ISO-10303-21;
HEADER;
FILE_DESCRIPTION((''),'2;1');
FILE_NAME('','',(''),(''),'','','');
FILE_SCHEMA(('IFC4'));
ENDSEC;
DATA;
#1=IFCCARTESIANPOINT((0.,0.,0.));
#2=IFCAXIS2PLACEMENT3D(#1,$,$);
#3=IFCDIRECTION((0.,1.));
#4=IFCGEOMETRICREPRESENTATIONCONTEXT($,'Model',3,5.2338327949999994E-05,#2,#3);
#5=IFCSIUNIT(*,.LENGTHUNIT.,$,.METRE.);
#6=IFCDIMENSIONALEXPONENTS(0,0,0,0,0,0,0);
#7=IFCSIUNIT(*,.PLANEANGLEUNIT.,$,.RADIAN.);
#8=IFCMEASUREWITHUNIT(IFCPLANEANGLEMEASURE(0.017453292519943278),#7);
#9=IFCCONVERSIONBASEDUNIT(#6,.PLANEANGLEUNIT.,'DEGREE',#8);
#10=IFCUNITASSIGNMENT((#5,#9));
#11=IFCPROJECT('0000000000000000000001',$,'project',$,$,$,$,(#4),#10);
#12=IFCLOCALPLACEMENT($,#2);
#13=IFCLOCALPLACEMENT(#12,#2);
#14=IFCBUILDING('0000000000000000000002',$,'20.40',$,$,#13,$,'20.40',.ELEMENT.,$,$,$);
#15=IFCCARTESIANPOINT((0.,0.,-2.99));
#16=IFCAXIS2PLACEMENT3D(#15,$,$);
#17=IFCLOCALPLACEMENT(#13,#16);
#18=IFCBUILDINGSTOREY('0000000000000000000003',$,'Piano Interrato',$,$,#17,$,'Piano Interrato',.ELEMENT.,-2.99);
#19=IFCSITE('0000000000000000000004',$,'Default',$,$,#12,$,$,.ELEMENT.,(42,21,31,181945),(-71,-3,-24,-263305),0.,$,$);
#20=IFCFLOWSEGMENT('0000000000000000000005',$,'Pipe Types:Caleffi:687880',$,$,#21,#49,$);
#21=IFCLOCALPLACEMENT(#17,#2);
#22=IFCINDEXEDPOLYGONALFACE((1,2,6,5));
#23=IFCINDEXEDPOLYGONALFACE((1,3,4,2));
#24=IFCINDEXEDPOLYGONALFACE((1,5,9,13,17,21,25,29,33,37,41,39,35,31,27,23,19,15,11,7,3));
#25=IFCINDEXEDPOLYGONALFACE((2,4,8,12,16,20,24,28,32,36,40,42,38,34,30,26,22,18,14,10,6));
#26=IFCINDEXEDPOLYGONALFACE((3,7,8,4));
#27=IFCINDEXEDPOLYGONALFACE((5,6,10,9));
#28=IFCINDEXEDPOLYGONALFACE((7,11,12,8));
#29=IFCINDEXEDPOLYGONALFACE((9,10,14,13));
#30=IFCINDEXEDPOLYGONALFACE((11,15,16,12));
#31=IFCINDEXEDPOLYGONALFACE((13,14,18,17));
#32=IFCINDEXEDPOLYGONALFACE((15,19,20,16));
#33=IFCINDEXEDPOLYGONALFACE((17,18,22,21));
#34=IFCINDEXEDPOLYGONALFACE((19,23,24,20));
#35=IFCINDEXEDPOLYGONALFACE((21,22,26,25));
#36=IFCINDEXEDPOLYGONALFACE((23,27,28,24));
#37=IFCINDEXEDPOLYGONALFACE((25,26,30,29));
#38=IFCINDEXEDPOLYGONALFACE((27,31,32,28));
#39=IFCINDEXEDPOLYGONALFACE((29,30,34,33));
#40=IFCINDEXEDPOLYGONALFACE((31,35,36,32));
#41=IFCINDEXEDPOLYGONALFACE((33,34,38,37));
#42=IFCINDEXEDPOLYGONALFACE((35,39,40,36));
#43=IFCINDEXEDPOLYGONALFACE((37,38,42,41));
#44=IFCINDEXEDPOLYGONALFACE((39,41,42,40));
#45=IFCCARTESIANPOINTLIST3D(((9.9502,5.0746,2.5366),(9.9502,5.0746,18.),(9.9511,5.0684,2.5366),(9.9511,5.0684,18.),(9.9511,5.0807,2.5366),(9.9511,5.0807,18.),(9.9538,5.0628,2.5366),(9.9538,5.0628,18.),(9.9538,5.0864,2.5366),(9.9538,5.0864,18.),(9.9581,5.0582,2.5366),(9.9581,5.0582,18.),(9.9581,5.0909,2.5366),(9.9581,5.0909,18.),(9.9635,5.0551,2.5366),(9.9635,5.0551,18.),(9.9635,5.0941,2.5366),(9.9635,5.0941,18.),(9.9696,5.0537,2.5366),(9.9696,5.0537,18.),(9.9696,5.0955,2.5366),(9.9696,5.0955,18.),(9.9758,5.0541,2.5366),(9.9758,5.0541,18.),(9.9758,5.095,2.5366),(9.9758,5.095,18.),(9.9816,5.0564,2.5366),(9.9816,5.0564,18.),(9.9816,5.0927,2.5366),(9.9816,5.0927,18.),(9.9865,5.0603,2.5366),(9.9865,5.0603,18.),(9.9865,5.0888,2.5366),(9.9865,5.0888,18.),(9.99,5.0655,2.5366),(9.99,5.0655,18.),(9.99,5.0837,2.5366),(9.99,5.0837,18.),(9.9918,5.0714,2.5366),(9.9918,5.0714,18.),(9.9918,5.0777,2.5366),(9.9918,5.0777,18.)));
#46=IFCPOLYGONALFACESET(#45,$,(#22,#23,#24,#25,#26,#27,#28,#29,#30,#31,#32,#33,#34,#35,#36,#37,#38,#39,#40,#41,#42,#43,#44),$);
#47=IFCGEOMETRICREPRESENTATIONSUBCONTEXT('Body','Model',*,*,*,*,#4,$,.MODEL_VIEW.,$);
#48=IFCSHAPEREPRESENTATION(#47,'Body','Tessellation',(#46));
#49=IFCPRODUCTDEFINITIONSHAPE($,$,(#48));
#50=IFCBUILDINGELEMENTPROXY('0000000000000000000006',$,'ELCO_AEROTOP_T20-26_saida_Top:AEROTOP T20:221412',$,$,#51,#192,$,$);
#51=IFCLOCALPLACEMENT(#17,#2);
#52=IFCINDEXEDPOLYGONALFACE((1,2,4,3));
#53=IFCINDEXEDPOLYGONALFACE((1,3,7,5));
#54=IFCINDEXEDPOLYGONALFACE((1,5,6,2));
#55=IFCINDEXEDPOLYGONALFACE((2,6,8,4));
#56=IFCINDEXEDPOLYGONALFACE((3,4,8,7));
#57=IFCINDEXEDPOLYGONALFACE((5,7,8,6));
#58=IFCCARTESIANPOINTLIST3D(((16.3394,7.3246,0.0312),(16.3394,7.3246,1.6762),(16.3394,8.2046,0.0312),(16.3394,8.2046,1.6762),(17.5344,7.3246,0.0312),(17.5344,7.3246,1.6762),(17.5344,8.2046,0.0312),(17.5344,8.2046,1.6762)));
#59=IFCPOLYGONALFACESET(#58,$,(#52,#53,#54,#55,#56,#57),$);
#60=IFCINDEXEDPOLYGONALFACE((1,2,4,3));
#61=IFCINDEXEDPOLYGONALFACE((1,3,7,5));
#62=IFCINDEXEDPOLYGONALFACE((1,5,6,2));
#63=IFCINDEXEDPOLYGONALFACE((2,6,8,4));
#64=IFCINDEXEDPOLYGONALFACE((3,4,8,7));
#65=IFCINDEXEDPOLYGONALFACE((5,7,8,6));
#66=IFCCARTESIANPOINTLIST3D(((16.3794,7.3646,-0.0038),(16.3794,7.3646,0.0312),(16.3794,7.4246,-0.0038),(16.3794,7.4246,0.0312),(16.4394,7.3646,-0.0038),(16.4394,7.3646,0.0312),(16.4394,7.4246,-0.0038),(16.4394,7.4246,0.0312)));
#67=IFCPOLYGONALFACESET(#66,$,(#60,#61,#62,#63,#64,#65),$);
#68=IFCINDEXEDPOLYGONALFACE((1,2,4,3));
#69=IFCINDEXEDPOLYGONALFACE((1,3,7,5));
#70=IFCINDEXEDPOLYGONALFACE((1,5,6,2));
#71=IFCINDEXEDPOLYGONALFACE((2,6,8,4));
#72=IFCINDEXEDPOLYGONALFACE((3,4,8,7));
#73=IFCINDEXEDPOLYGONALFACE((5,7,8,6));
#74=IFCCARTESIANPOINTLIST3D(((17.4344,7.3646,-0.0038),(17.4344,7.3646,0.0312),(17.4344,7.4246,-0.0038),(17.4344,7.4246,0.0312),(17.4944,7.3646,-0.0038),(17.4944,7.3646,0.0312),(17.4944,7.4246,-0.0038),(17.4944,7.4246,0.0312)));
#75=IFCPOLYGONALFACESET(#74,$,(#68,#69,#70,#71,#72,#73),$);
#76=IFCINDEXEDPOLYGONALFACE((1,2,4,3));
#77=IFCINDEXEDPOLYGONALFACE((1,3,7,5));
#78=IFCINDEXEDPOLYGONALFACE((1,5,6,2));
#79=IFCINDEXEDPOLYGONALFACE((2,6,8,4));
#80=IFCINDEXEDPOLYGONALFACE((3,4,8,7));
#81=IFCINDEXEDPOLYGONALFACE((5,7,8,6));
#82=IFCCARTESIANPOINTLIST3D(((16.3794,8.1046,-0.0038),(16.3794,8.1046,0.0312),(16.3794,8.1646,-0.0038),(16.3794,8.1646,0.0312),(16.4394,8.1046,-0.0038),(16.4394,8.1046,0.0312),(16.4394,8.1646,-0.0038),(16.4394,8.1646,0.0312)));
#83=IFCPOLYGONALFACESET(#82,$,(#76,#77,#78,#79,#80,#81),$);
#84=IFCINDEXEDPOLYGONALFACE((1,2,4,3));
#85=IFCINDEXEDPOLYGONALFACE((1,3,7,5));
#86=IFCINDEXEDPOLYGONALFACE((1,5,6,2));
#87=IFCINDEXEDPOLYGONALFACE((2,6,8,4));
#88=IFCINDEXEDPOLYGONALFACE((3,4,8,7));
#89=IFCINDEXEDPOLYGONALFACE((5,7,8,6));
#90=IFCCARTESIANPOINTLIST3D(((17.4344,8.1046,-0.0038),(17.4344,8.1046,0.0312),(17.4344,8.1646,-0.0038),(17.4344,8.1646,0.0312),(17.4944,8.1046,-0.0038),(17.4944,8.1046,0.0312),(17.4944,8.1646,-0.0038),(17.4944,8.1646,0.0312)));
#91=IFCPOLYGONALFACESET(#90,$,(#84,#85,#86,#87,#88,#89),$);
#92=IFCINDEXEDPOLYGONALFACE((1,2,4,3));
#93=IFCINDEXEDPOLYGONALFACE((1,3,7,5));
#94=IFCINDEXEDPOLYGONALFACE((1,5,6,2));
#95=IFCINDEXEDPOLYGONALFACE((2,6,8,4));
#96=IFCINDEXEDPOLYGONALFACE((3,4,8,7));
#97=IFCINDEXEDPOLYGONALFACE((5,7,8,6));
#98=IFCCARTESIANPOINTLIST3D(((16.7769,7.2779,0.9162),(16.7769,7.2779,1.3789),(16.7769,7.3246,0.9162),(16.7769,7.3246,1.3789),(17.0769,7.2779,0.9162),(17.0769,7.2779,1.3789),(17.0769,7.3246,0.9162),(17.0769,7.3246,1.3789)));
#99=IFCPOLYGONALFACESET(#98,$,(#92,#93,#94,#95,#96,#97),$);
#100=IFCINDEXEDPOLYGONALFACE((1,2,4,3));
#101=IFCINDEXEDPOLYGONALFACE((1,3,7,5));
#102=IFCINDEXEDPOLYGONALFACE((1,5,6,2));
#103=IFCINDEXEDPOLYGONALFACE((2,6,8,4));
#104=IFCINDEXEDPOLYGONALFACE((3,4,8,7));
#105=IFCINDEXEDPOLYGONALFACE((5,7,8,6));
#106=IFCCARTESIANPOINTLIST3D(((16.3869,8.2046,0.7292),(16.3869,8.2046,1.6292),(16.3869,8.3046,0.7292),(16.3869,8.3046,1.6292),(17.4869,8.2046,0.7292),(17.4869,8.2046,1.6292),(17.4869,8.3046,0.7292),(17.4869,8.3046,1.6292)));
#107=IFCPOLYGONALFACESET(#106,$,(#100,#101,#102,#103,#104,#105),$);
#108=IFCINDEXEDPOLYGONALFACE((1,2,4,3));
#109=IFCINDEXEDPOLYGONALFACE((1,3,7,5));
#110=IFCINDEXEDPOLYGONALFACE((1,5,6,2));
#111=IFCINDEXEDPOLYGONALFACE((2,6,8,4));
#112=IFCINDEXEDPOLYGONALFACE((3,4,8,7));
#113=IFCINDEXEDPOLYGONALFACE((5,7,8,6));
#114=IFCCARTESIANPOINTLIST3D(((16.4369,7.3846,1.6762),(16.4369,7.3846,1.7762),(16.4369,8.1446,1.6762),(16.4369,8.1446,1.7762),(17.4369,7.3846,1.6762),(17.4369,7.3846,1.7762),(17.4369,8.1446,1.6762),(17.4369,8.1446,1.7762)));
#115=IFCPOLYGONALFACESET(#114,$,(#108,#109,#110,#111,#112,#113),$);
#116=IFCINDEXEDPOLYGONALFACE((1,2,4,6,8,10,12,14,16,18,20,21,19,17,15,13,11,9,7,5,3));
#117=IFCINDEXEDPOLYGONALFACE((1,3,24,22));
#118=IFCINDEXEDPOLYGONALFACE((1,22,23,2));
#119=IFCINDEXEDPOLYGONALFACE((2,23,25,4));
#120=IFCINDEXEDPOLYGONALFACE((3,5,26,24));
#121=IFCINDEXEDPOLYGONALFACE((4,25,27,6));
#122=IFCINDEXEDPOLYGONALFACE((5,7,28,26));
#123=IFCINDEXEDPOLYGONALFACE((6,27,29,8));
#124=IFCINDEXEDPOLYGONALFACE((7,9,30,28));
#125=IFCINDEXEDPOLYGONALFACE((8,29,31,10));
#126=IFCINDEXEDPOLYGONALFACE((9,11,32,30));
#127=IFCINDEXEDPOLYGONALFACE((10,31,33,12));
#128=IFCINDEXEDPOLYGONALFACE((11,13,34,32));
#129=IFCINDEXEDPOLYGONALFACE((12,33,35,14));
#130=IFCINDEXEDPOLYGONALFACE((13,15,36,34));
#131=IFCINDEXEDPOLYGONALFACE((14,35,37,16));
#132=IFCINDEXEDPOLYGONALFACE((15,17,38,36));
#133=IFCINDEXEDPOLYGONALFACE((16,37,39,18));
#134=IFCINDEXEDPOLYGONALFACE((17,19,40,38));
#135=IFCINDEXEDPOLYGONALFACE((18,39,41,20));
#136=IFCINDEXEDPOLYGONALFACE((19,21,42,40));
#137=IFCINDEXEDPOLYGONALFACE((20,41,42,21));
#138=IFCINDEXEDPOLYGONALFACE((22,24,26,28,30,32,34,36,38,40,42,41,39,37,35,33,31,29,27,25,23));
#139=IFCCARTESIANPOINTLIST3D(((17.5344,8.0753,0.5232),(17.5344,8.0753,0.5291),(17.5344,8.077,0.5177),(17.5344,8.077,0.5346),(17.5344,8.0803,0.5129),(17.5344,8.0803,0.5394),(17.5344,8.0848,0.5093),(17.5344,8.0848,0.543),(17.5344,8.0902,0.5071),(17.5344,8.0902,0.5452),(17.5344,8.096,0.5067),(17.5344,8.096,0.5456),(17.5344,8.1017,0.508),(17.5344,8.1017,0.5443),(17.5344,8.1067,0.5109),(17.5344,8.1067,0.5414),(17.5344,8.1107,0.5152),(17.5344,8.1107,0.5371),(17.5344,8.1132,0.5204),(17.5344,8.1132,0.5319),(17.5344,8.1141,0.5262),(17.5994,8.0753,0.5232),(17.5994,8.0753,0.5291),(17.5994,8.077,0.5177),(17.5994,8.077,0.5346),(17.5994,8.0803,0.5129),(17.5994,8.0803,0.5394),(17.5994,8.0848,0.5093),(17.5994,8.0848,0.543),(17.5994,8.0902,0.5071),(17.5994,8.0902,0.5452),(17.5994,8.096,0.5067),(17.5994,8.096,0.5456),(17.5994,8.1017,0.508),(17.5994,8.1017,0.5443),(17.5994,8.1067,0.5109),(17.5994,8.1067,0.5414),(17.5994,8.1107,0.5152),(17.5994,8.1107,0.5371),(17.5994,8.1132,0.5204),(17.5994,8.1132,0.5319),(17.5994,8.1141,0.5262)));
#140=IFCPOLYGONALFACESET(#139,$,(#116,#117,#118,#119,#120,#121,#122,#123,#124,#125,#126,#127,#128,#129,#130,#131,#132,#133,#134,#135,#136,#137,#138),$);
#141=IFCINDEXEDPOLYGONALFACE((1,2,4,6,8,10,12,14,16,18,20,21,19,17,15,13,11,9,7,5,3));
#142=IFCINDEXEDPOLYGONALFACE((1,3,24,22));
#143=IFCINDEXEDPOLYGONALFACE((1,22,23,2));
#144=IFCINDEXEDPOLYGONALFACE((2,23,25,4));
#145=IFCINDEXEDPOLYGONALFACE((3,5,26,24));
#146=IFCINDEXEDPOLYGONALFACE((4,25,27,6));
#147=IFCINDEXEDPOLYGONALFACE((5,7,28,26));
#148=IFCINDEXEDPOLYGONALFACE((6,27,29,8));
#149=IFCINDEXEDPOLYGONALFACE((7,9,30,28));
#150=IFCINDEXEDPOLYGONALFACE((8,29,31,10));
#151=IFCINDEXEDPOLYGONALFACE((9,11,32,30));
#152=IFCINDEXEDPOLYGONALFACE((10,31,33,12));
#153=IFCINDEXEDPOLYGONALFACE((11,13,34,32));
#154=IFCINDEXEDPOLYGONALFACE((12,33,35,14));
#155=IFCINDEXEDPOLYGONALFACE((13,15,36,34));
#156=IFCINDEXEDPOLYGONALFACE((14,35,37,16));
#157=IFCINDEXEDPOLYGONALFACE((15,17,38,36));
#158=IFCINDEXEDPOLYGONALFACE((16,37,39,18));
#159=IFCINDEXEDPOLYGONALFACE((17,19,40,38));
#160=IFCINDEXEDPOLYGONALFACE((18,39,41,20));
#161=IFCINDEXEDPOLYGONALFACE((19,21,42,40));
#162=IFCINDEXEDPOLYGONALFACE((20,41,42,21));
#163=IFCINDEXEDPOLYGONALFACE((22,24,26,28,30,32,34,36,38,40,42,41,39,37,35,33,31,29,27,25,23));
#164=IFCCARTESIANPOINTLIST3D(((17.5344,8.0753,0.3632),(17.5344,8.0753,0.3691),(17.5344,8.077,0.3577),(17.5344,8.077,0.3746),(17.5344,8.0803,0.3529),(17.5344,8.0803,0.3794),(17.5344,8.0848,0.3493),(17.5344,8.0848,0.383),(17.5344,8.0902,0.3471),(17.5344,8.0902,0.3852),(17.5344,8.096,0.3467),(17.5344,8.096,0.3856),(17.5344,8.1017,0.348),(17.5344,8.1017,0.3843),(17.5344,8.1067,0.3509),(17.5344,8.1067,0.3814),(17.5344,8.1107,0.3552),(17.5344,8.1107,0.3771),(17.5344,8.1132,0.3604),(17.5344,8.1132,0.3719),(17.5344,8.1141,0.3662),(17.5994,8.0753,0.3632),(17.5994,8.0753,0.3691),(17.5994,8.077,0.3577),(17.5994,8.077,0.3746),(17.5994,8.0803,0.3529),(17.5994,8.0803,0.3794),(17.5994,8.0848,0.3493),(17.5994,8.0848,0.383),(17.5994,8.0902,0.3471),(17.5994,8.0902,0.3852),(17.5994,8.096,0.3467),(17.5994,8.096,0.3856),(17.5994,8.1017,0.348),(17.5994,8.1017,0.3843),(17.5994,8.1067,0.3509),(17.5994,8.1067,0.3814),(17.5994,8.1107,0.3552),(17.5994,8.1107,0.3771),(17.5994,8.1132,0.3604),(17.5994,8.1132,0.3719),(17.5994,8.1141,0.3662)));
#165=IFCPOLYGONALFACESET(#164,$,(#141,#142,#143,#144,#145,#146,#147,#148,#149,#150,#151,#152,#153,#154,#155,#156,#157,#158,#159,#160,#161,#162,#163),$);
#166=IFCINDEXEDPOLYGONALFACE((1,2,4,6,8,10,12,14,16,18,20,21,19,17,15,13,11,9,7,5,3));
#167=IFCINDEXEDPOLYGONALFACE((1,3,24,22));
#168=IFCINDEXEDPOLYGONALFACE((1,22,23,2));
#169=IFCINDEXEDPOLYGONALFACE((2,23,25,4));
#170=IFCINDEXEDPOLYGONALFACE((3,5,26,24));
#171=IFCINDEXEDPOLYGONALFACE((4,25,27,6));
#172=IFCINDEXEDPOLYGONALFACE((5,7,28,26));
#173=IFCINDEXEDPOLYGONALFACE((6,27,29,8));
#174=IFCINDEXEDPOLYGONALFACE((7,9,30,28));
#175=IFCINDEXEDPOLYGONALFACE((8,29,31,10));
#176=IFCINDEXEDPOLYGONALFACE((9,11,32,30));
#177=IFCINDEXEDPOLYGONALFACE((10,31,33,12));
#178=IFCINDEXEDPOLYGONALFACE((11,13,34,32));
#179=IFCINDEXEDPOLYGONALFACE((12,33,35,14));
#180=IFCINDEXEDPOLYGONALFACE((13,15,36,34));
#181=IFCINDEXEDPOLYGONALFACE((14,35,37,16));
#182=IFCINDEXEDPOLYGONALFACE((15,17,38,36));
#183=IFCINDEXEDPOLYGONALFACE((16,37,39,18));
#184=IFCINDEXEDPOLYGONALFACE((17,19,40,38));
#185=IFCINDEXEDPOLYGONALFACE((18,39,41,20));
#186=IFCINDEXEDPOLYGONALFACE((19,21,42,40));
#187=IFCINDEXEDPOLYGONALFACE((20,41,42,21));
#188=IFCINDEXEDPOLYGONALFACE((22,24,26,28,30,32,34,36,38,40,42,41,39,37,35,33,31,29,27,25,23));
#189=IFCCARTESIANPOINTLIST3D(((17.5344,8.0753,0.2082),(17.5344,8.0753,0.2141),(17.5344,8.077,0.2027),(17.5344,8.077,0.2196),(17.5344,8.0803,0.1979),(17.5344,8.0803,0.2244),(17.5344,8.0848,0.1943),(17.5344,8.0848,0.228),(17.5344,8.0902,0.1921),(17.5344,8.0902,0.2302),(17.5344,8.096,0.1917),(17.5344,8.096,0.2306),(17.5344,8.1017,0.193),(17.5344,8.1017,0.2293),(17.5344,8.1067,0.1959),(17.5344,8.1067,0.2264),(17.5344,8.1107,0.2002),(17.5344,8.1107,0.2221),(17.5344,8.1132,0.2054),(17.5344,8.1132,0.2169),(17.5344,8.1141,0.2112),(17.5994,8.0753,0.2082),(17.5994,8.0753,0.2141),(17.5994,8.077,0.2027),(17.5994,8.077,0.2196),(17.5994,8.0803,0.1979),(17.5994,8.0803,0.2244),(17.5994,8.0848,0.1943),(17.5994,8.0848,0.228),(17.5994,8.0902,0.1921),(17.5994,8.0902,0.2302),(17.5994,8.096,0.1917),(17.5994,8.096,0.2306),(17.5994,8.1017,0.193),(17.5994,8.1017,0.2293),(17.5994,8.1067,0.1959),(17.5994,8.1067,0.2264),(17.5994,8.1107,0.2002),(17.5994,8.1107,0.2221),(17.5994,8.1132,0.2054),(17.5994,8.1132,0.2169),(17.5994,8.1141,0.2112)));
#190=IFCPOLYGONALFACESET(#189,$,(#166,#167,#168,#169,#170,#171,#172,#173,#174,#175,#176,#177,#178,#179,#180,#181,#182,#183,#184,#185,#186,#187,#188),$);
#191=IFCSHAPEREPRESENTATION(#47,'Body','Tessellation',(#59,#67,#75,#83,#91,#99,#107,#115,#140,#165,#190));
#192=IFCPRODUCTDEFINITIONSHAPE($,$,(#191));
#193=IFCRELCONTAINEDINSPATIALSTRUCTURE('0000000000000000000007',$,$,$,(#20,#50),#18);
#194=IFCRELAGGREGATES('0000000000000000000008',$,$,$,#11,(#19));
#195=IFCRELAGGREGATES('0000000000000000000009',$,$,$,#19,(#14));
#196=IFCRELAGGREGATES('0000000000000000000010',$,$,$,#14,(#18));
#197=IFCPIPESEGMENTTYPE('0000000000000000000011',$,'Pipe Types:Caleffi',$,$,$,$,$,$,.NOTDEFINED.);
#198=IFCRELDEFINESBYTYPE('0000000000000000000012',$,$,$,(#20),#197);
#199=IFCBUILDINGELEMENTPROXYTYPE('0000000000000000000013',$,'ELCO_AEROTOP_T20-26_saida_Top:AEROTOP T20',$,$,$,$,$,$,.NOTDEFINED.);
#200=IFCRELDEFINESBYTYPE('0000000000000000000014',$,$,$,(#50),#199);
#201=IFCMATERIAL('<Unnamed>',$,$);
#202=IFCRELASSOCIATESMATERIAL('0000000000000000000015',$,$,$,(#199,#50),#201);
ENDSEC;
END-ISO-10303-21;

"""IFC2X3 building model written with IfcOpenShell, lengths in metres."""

from ifc_helpers import new_model, entity, si_unit, converted_unit, direction, frame, frame_2d, origin, origin_2d_with_axis, place, context, subcontext, project, spatial, rectangle, circle, extrude, source, transform, mapped, material, type_object, type_shapes, element, save


model = new_model("IFC2X3")

# Units and contexts
model_context = context("Model", 3, precision=5.2338327949999994e-05, world=origin(), true_north=direction((0.0, 1.0)))
body_context = subcontext(model_context, "Body", "Model", "MODEL_VIEW")
ifc_project = project(units=[si_unit("LENGTHUNIT", "METRE"), converted_unit("PLANEANGLEUNIT", "DEGREE", entity("IfcPlaneAngleMeasure", 0.017453292519943278), si_unit("PLANEANGLEUNIT", "RADIAN"), dimensions=[0, 0, 0, 0, 0, 0, 0])], contexts=[model_context])

# Site, building, storey
site_placement = place(None, origin())
site = spatial("IfcSite", under=ifc_project, at=site_placement, Name="Default", CompositionType="ELEMENT", RefLatitude=(42, 21, 31, 181945), RefLongitude=(-71, -3, -24, -263305), RefElevation=0.0)
building_placement = place(site_placement, origin())
building = spatial("IfcBuilding", under=site, at=building_placement, Name="20.40", LongName="20.40", CompositionType="ELEMENT")
storey_placement = place(building_placement, frame((0.0, 0.0, -2.99)))
storey = spatial("IfcBuildingStorey", under=building, at=storey_placement, Name="Piano Interrato", LongName="Piano Interrato", CompositionType="ELEMENT", Elevation=-2.99)

# Shared definitions
ifc_material = material(Name="<Unnamed>")

# Flow segment
pipe_segment_type_1 = type_object("IfcPipeSegmentType", Name="Pipe Types:Caleffi", PredefinedType="NOTDEFINED")
flow_segment_1_placement = place(storey_placement, origin())
element("IfcFlowSegment", 1, at=flow_segment_1_placement, inside=storey, type_object=pipe_segment_type_1, Name="Pipe Types:Caleffi:687880", context=body_context, shape_type="SweptSolid", body=[
    extrude(circle(Radius=0.0209, at=origin_2d_with_axis()), frame((9.9711, 5.0746, 2.5366), z_axis=(0.0, 0.0, 1.0), x_axis=(-1.0, 0.0, 0.0)), (0.0, 0.0, 1.0), 15.4634),
])

# Building element proxy
building_element_proxy_type = type_object("IfcBuildingElementProxyType", Name="ELCO_AEROTOP_T20-26_saida_Top:AEROTOP T20", PredefinedType="NOTDEFINED", material=ifc_material)
shared_shape_1 = source(origin(), body_context, "Body", "SweptSolid", [
    extrude(rectangle(XDim=0.88, YDim=1.195, at=origin_2d_with_axis()), frame((0.5975, 0.44, 0.035), z_axis=(0.0, 0.0, 1.0), x_axis=(0.0, 1.0, 0.0)), (0.0, 0.0, 1.0), 1.645),
    extrude(rectangle(XDim=0.06, YDim=0.06, at=frame_2d((0.0, 0.0), x_axis=(1.0, 0.0))), frame((0.07, 0.07, 0.0), z_axis=(0.0, 0.0, 1.0), x_axis=(0.0, 1.0, 0.0)), (0.0, 0.0, 1.0), 0.035),
    extrude(rectangle(XDim=0.06, YDim=0.06, at=frame_2d((0.0, 0.0), x_axis=(1.0, 0.0))), frame((1.125, 0.07, 0.0), z_axis=(0.0, 0.0, 1.0), x_axis=(0.0, 1.0, 0.0)), (0.0, 0.0, 1.0), 0.035),
    extrude(rectangle(XDim=0.06, YDim=0.06, at=frame_2d((0.0, 0.0), x_axis=(1.0, 0.0))), frame((0.07, 0.81, 0.0), z_axis=(0.0, 0.0, 1.0), x_axis=(0.0, 1.0, 0.0)), (0.0, 0.0, 1.0), 0.035),
    extrude(rectangle(XDim=0.06, YDim=0.06, at=frame_2d((0.0, 0.0), x_axis=(1.0, 0.0))), frame((1.125, 0.81, 0.0), z_axis=(0.0, 0.0, 1.0), x_axis=(0.0, 1.0, 0.0)), (0.0, 0.0, 1.0), 0.035),
    extrude(rectangle(XDim=0.0467, YDim=0.3, at=origin_2d_with_axis()), frame((0.5875, -0.0233, 0.92), z_axis=(0.0, 0.0, 1.0), x_axis=(0.0, -1.0, 0.0)), (0.0, 0.0, 1.0), 0.4627),
    extrude(rectangle(XDim=0.1, YDim=1.1, at=frame_2d((0.0, 0.0), x_axis=(1.0, 0.0))), frame((0.5975, 0.93, 0.733), z_axis=(0.0, 0.0, 1.0), x_axis=(0.0, -1.0, 0.0)), (0.0, 0.0, 1.0), 0.9),
    extrude(rectangle(XDim=0.76, YDim=1.0, at=origin_2d_with_axis()), frame((0.5975, 0.44, 1.68), z_axis=(0.0, 0.0, 1.0), x_axis=(0.0, 1.0, 0.0)), (0.0, 0.0, 1.0), 0.1),
    extrude(circle(Radius=0.0195, at=origin_2d_with_axis()), frame((1.195, 0.77, 0.53), z_axis=(1.0, 0.0, 0.0), x_axis=(0.0, 1.0, 0.0)), (0.0, 0.0, 1.0), 0.065),
    extrude(circle(Radius=0.0195, at=origin_2d_with_axis()), frame((1.195, 0.77, 0.37), z_axis=(1.0, 0.0, 0.0), x_axis=(0.0, 1.0, 0.0)), (0.0, 0.0, 1.0), 0.065),
    extrude(circle(Radius=0.0195, at=origin_2d_with_axis()), frame((1.195, 0.77, 0.215), z_axis=(1.0, 0.0, 0.0), x_axis=(0.0, 1.0, 0.0)), (0.0, 0.0, 1.0), 0.065),
])
type_shapes(building_element_proxy_type, [shared_shape_1])
proxy_placement = place(storey_placement, frame((16.3394, 7.3246, -0.0038)))
element("IfcBuildingElementProxy", 2, at=proxy_placement, inside=storey, type_object=building_element_proxy_type, material=ifc_material, Name="ELCO_AEROTOP_T20-26_saida_Top:AEROTOP T20:221412", context=body_context, shape_type="MappedRepresentation", body=[
    mapped(shared_shape_1, transform((0.0, 0.0, 0.0), scale=1.0)),
])

save(model, "model.ifc")
